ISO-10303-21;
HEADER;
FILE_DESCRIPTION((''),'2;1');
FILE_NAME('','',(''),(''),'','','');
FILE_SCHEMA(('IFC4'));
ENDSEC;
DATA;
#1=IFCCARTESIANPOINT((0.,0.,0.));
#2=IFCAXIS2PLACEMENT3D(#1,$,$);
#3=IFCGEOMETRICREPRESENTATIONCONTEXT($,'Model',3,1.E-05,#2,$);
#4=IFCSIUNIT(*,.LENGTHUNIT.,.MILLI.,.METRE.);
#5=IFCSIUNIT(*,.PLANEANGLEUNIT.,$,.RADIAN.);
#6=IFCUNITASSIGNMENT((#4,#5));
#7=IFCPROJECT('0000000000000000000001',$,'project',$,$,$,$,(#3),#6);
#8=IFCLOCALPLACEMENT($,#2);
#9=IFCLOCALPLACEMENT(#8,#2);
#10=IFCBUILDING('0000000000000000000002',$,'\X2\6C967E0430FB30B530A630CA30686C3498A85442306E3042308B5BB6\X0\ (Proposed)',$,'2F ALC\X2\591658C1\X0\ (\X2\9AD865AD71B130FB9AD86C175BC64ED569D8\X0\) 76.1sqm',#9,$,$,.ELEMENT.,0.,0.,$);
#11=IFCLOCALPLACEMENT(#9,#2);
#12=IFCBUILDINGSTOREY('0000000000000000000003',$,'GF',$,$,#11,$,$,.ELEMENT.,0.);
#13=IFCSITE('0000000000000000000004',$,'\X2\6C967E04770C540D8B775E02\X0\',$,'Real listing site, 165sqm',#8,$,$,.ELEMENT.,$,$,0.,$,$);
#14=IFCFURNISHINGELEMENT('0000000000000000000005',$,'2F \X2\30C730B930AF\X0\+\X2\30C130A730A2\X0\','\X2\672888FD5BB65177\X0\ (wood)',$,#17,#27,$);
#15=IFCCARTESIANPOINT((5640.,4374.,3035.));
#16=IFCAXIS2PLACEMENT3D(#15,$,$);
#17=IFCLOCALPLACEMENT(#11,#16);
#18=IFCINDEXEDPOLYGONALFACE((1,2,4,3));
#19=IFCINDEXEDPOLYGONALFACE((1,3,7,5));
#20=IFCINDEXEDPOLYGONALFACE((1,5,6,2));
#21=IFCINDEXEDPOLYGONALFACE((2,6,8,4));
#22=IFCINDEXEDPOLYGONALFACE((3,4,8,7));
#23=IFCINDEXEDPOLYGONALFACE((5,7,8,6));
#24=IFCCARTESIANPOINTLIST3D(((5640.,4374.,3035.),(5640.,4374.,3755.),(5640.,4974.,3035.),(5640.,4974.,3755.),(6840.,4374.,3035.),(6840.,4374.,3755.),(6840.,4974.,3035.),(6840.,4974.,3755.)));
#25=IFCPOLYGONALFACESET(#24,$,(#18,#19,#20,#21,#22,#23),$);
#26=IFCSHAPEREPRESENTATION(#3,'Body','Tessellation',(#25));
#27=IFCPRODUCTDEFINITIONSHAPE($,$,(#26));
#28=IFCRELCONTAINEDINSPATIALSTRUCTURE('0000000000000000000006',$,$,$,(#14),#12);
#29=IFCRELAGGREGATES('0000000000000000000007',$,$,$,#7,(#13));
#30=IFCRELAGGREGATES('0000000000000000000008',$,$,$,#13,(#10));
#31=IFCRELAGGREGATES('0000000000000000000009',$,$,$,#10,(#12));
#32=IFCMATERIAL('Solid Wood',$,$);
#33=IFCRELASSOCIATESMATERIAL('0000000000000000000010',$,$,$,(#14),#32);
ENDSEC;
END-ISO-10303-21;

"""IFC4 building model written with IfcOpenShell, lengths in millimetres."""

from ifc_helpers import new_model, si_unit, frame, frame_2d, origin, place, context, project, spatial, rectangle, extrude, material, element, save


model = new_model("IFC4")

# Units and contexts
model_context = context("Model", 3, precision=1e-05, world=origin())
ifc_project = project(units=[si_unit("LENGTHUNIT", "METRE", prefix="MILLI"), si_unit("PLANEANGLEUNIT", "RADIAN")], contexts=[model_context])

# Site, building, storey
site_placement = place(None, origin())
site = spatial("IfcSite", under=ifc_project, at=site_placement, Name="沖縄県名護市", ObjectType="Real listing site, 165sqm", CompositionType="ELEMENT", RefElevation=0.0)
building_placement = place(site_placement, origin())
building = spatial("IfcBuilding", under=site, at=building_placement, Name="沖縄・サウナと水風呂のある家 (Proposed)", ObjectType="2F ALC外壁 (高断熱・高気密仕様) 76.1sqm", CompositionType="ELEMENT", ElevationOfRefHeight=0.0, ElevationOfTerrain=0.0)
storey_placement = place(building_placement, origin())
storey = spatial("IfcBuildingStorey", under=building, at=storey_placement, Name="GF", CompositionType="ELEMENT", Elevation=0.0)

# Shared definitions
ifc_material_1 = material(Name="Solid Wood")

# Furnishing element
furnishing_1_placement = place(storey_placement, frame((5640.0, 4374.0, 3035.0)))
element("IfcFurnishingElement", 1, at=furnishing_1_placement, inside=storey, material=ifc_material_1, Name="2F デスク+チェア", Description="木製家具 (wood)", context=model_context, shape_type="SweptSolid", body=[
    extrude(rectangle(XDim=1200.0, YDim=600.0, at=frame_2d((600.0, 300.0))), frame((5640.0, 4374.0, 3035.0)), (0.0, 0.0, 1.0), 720.0),
])

save(model, "model.ifc")
